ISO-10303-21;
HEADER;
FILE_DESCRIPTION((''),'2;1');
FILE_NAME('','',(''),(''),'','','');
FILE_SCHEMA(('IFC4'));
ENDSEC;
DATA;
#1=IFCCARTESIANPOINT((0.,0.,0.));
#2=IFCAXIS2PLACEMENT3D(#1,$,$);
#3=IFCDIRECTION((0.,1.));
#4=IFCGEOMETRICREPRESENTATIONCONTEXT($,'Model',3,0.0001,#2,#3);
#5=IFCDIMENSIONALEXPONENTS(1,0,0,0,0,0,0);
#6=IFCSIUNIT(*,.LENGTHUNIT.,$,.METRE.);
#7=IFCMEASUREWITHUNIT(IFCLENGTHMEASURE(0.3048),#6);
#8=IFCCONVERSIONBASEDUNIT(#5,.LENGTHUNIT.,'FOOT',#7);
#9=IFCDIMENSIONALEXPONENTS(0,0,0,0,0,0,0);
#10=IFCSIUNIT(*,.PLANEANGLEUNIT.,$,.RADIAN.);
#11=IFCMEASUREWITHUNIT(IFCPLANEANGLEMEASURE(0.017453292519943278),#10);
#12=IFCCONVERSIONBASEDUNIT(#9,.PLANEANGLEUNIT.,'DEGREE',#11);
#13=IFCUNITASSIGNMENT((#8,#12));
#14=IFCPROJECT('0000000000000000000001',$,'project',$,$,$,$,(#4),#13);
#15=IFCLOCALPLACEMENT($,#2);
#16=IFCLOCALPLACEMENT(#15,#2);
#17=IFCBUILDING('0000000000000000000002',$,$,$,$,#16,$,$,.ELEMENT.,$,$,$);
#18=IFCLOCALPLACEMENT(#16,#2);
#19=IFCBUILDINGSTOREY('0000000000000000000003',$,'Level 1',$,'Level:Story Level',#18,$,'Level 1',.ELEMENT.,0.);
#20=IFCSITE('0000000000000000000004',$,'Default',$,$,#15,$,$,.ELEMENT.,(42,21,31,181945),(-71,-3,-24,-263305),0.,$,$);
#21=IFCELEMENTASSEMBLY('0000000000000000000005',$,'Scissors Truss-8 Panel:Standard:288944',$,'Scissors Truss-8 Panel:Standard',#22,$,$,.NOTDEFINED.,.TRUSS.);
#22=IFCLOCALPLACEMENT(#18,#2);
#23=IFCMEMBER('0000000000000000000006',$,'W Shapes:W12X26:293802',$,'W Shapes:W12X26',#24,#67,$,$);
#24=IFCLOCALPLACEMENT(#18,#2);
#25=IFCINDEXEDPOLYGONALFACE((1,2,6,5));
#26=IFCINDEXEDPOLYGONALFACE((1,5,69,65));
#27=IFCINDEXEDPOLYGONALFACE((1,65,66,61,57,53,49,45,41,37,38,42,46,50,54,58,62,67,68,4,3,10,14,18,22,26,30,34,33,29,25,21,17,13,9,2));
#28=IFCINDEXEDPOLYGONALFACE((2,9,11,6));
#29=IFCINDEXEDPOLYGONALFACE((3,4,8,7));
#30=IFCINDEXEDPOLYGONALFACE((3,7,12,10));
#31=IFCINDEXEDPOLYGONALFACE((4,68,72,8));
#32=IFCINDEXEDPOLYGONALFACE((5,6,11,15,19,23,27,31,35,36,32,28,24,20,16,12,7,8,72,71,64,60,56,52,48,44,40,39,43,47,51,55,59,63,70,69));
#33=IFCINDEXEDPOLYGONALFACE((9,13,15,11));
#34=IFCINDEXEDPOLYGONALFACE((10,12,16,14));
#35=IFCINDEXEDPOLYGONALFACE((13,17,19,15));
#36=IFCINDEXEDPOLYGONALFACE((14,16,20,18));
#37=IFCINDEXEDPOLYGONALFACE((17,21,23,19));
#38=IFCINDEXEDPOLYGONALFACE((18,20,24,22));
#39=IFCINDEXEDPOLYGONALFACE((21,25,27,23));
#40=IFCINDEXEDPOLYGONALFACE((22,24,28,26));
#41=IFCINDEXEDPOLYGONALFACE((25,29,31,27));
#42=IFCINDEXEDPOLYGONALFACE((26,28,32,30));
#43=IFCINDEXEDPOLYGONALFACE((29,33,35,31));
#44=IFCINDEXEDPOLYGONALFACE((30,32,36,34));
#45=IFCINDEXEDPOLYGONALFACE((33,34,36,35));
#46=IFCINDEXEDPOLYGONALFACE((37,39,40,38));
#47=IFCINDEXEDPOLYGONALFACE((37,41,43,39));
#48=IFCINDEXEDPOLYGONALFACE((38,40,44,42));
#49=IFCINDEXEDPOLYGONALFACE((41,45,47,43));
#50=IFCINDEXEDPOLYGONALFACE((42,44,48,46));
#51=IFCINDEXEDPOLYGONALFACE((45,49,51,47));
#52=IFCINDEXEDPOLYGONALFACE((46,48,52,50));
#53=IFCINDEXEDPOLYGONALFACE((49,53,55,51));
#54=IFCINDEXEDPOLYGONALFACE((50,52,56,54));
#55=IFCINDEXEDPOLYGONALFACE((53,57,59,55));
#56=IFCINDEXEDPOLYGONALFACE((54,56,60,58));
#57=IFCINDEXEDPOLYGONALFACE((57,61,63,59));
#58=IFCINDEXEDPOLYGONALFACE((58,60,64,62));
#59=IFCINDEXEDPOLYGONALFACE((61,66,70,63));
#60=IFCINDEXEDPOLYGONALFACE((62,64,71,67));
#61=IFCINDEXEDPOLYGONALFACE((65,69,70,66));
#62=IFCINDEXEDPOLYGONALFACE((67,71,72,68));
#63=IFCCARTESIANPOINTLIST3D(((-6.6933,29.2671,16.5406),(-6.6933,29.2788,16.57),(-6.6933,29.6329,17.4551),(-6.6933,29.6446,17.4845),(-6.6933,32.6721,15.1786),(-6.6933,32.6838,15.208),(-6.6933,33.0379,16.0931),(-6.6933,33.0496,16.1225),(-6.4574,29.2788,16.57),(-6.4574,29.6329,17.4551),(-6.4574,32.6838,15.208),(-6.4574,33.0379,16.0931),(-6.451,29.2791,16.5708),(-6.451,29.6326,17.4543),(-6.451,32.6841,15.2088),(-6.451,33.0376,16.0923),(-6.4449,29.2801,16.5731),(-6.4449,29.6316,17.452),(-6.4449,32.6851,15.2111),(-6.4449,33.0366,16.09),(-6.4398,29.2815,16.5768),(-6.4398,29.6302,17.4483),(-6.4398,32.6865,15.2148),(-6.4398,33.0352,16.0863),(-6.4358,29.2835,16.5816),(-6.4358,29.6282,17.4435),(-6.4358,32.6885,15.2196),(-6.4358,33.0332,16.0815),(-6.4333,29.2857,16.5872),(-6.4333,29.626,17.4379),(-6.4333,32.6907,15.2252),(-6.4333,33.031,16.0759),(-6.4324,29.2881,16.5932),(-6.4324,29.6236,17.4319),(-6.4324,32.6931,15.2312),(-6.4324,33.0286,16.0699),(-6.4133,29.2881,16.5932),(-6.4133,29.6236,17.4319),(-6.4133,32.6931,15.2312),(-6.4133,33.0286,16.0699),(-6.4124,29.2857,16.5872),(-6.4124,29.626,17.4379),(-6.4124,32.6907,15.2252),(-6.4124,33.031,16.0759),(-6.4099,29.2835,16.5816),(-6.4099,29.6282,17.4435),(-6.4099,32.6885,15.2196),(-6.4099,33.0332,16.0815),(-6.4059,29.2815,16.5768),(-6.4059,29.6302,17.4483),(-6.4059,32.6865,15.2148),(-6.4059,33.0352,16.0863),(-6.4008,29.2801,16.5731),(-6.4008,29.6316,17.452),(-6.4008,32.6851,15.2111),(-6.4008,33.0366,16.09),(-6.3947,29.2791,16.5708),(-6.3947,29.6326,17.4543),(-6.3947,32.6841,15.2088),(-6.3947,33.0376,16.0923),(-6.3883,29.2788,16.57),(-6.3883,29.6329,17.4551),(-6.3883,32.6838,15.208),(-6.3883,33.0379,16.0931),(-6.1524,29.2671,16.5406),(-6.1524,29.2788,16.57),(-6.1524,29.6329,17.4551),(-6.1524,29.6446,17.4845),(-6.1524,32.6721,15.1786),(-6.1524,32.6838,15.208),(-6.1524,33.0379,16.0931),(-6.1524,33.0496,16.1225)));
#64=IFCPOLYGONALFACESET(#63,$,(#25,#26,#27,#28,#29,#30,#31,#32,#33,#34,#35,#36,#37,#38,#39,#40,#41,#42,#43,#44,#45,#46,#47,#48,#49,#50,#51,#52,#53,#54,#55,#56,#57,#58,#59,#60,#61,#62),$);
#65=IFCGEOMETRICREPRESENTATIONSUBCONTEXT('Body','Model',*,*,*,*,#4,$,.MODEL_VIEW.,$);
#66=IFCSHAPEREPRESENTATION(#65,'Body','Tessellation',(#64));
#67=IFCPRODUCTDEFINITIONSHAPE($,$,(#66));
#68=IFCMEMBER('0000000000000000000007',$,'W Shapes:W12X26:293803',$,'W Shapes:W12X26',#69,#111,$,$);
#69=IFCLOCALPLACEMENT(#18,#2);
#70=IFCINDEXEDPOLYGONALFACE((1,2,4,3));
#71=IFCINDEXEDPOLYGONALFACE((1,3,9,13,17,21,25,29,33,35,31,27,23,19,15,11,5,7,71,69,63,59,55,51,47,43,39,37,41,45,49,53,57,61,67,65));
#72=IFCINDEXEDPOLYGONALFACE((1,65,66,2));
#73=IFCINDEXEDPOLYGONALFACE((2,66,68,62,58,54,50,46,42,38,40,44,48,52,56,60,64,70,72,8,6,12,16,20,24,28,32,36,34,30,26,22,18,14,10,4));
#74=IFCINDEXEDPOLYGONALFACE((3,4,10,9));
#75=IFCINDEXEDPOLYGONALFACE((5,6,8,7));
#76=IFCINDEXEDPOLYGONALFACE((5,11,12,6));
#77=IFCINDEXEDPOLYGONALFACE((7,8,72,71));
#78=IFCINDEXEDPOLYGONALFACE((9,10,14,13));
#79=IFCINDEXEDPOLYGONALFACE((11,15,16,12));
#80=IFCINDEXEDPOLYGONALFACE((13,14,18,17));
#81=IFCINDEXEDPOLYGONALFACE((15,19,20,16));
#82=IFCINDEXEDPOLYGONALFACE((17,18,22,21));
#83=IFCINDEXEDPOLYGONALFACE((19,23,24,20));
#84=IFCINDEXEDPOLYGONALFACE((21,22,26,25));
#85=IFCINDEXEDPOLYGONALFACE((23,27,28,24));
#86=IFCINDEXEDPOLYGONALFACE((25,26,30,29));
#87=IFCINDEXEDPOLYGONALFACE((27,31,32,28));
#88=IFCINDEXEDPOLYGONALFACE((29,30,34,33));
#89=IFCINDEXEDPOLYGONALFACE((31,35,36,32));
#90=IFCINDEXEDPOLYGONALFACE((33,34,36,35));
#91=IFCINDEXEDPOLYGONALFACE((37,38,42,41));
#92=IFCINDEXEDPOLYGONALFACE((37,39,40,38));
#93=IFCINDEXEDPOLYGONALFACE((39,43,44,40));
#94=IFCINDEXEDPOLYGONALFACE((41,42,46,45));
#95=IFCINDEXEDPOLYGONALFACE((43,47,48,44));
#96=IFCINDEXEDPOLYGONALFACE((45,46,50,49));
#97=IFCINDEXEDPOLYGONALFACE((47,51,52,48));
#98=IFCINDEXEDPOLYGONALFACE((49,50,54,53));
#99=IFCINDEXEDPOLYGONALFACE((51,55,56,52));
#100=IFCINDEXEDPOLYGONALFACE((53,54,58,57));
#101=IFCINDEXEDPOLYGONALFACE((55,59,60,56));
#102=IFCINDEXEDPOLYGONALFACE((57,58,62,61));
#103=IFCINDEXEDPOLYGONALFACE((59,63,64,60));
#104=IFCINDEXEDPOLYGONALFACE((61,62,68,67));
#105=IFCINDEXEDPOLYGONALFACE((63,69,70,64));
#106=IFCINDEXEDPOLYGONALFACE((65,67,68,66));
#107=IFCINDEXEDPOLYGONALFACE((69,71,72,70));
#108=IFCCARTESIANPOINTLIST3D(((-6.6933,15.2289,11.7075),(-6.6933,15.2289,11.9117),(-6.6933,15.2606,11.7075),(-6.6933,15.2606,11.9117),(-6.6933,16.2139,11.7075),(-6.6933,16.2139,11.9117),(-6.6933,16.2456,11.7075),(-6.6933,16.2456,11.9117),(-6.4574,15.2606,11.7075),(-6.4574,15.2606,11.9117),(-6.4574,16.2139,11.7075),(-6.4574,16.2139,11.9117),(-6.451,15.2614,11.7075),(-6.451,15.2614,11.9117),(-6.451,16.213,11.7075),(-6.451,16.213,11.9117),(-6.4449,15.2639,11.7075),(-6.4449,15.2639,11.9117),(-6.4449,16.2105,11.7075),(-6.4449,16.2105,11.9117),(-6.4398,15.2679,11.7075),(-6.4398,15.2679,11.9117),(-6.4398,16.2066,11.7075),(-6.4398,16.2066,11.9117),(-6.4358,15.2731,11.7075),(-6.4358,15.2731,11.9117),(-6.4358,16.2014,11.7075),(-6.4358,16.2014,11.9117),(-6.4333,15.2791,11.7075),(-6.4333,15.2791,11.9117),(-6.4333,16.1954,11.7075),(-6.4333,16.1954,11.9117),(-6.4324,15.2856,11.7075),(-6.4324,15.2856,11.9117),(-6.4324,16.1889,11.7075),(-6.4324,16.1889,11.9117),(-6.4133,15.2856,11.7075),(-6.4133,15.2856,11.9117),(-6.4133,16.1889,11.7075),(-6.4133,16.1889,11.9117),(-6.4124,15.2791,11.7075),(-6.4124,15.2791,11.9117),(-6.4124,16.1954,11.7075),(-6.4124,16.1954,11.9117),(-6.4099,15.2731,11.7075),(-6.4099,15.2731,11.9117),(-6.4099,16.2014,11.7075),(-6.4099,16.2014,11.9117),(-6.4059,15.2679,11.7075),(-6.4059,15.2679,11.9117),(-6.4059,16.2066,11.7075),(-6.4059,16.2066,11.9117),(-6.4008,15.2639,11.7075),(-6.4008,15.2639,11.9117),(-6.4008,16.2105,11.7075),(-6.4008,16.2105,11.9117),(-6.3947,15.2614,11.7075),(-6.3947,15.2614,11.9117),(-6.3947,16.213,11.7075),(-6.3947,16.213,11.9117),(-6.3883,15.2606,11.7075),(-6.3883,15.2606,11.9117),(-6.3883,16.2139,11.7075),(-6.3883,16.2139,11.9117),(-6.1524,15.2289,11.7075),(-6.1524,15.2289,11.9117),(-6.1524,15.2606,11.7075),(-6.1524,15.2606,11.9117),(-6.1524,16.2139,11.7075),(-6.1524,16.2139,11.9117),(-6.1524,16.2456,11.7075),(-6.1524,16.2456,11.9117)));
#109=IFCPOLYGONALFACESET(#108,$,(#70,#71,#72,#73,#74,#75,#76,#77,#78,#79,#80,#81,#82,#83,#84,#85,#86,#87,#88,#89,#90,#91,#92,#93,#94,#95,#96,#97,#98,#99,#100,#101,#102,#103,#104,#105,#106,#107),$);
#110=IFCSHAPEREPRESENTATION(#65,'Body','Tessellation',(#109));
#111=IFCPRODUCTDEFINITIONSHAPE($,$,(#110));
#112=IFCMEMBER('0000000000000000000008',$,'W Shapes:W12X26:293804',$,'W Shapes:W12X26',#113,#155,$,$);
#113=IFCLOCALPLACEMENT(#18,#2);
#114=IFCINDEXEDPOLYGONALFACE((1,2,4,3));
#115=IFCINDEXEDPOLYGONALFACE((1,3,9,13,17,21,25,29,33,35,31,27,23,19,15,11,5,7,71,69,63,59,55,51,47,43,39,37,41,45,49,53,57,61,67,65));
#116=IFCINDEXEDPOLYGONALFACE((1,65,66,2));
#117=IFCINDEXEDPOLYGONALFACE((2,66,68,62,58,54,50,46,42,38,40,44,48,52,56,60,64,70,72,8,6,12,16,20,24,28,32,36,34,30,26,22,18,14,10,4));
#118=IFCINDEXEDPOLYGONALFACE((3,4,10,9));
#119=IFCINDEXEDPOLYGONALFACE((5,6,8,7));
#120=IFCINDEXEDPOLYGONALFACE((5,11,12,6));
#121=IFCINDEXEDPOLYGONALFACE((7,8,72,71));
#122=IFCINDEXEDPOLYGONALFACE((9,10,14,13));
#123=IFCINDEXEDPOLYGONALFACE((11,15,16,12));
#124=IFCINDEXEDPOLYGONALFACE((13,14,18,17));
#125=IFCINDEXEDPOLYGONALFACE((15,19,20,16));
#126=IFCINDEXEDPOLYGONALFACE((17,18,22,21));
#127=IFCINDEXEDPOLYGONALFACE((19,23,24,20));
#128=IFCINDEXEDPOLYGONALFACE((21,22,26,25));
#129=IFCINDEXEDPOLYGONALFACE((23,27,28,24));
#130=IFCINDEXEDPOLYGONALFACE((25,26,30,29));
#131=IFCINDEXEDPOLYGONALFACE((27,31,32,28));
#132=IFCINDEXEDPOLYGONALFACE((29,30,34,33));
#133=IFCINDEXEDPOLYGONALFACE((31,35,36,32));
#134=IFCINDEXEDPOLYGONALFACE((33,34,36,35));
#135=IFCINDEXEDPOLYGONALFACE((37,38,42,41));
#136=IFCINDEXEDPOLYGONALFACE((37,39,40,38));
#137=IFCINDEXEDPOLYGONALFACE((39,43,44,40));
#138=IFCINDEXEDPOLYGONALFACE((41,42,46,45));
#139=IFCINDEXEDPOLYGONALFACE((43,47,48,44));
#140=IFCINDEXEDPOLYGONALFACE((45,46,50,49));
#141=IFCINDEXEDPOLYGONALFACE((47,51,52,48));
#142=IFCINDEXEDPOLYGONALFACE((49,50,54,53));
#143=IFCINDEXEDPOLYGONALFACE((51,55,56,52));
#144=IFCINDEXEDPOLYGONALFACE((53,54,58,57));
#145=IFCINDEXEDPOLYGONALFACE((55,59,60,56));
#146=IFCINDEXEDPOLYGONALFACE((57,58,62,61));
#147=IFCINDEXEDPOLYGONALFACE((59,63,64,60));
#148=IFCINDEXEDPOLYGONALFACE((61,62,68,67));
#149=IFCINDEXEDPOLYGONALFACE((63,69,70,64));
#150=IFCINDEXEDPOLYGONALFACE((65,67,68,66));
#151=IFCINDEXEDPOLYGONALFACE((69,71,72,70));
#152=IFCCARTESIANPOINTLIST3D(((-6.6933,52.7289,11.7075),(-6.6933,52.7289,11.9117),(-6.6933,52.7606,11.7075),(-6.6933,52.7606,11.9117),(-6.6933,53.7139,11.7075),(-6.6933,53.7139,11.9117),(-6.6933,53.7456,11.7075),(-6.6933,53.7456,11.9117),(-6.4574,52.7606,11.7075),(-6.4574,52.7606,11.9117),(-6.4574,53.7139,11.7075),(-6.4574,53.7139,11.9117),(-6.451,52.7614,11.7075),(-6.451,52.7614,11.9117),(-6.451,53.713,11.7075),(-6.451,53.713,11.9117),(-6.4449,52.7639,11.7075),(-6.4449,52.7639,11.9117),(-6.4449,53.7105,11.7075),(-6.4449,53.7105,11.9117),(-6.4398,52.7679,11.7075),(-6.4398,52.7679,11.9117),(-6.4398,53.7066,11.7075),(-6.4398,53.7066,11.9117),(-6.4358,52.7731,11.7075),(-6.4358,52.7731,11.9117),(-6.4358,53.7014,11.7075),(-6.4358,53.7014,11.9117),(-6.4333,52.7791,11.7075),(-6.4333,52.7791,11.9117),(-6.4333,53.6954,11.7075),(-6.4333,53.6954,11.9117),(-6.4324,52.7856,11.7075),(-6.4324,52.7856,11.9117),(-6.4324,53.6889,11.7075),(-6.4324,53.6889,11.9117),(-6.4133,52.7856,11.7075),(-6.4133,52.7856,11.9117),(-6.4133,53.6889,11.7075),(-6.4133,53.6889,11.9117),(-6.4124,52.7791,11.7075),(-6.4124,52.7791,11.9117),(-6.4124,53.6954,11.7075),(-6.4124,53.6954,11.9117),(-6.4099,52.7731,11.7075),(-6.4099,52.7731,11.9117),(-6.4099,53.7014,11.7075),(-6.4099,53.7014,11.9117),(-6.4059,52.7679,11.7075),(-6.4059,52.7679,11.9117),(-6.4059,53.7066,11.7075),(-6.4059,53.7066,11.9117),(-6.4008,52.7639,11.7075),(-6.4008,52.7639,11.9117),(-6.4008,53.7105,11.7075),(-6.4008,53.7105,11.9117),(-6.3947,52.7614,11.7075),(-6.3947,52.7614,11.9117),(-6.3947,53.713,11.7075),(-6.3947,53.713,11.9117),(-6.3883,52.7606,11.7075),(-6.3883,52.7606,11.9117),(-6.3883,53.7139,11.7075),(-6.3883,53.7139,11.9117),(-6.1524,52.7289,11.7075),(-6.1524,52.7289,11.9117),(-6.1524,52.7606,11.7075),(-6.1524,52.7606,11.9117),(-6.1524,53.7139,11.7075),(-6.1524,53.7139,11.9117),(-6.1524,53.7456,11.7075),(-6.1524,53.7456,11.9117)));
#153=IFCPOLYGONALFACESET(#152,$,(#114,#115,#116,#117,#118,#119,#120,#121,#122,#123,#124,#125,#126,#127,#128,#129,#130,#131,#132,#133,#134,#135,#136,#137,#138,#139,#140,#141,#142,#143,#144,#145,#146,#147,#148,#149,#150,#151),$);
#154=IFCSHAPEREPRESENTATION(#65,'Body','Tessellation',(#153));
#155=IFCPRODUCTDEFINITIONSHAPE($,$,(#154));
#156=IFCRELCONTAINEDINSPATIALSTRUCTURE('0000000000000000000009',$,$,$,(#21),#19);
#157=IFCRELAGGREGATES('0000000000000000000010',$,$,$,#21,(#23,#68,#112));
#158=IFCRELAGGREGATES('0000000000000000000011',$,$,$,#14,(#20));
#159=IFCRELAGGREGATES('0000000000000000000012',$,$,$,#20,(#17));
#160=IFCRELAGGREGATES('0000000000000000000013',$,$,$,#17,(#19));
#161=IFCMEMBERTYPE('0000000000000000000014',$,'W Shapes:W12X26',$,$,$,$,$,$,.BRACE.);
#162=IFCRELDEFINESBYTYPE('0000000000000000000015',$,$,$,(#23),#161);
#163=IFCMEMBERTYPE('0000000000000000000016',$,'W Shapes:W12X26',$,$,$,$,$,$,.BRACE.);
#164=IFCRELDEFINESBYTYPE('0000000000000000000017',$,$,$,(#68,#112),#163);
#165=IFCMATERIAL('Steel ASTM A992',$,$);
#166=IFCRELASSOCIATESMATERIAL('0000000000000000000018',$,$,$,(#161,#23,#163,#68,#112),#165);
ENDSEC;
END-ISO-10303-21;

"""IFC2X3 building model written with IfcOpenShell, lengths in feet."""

from ifc_helpers import new_model, entity, si_unit, converted_unit, direction, frame, frame_2d, origin, place, context, subcontext, project, spatial, polyline, circle_curve, parameter, trimmed, segment, composite_curve, outline, extrude, source, transform, mapped, material, type_object, type_shapes, element, aggregate, save


model = new_model("IFC2X3")

# Units and contexts
model_context = context("Model", 3, precision=0.0001, world=origin(), true_north=direction((0.0, 1.0)))
body_context = subcontext(model_context, "Body", "Model", "MODEL_VIEW")
ifc_project = project(units=[converted_unit("LENGTHUNIT", "FOOT", entity("IfcLengthMeasure", 0.3048), si_unit("LENGTHUNIT", "METRE"), dimensions=[1, 0, 0, 0, 0, 0, 0]), converted_unit("PLANEANGLEUNIT", "DEGREE", entity("IfcPlaneAngleMeasure", 0.017453292519943278), si_unit("PLANEANGLEUNIT", "RADIAN"), dimensions=[0, 0, 0, 0, 0, 0, 0])], contexts=[model_context])

# Site, building, storey
site_placement = place(None, origin())
site = spatial("IfcSite", under=ifc_project, at=site_placement, Name="Default", CompositionType="ELEMENT", RefLatitude=(42, 21, 31, 181945), RefLongitude=(-71, -3, -24, -263305), RefElevation=0.0)
building_placement = place(site_placement, origin())
building = spatial("IfcBuilding", under=site, at=building_placement, CompositionType="ELEMENT")
storey_placement = place(building_placement, origin())
storey = spatial("IfcBuildingStorey", under=building, at=storey_placement, Name="Level 1", ObjectType="Level:Story Level", LongName="Level 1", CompositionType="ELEMENT", Elevation=0.0)

# Element assembly, members
assembly_placement = place(storey_placement, origin())
assembly = element("IfcElementAssembly", 1, at=assembly_placement, inside=storey, Name="Scissors Truss-8 Panel:Standard:288944", ObjectType="Scissors Truss-8 Panel:Standard", AssemblyPlace="NOTDEFINED", PredefinedType="TRUSS")
ifc_material = material(Name="Steel ASTM A992")
member_type_1 = type_object("IfcMemberType", Name="W Shapes:W12X26", PredefinedType="BRACE", material=ifc_material)
shared_shape_1 = source(origin(), body_context, "Body", "SweptSolid", [
    extrude(outline(composite_curve([segment(polyline([(-0.2704, -0.4767), (-0.2704, -0.5083)]), True, "CONTINUOUS"), segment(polyline([(-0.2704, -0.5083), (0.2704, -0.5083)]), True, "CONTINUOUS"), segment(polyline([(0.2704, -0.5083), (0.2704, -0.4767)]), True, "CONTINUOUS"), segment(polyline([(0.2704, -0.4767), (0.0346, -0.4767)]), True, "CONTINUOUS"), segment(trimmed(circle_curve(frame_2d((0.0346, -0.4517), x_axis=(1.0, 0.0)), 0.025), [parameter(180.0)], [parameter(270.0)], True, "PARAMETER"), False, "CONTINUOUS"), segment(polyline([(0.0096, -0.4517), (0.0096, 0.4517)]), True, "CONTINUOUS"), segment(trimmed(circle_curve(frame_2d((0.0346, 0.4517), x_axis=(1.0, 0.0)), 0.025), [parameter(90.0)], [parameter(180.0)], True, "PARAMETER"), False, "CONTINUOUS"), segment(polyline([(0.0346, 0.4767), (0.2704, 0.4767)]), True, "CONTINUOUS"), segment(polyline([(0.2704, 0.4767), (0.2704, 0.5083)]), True, "CONTINUOUS"), segment(polyline([(0.2704, 0.5083), (-0.2704, 0.5083)]), True, "CONTINUOUS"), segment(polyline([(-0.2704, 0.5083), (-0.2704, 0.4767)]), True, "CONTINUOUS"), segment(polyline([(-0.2704, 0.4767), (-0.0346, 0.4767)]), True, "CONTINUOUS"), segment(trimmed(circle_curve(frame_2d((-0.0346, 0.4517), x_axis=(1.0, 0.0)), 0.025), [parameter(360.0)], [parameter(90.0)], True, "PARAMETER"), False, "CONTINUOUS"), segment(polyline([(-0.0096, 0.4517), (-0.0096, -0.4517)]), True, "CONTINUOUS"), segment(trimmed(circle_curve(frame_2d((-0.0346, -0.4517), x_axis=(1.0, 0.0)), 0.025), [parameter(270.0)], [parameter(360.0)], True, "PARAMETER"), False, "CONTINUOUS"), segment(polyline([(-0.0346, -0.4767), (-0.2704, -0.4767)]), True, "CONTINUOUS")], self_intersect=False)), frame((-2.0532, 0.0, 0.0), z_axis=(-1.0, 0.0, 0.0), x_axis=(0.0, -1.0, 0.0)), (0.0, 0.0, -1.0), 3.6673),
])
type_shapes(member_type_1, [shared_shape_1])
member_1_placement = place(assembly_placement, frame((-6.4228, 31.3622, 16.25), z_axis=(0.0, -0.371391, -0.928477), x_axis=(0.0, 0.928477, -0.371391)))
member_1 = element("IfcMember", 2, at=member_1_placement, type_object=member_type_1, material=ifc_material, Name="W Shapes:W12X26:293802", ObjectType="W Shapes:W12X26", context=body_context, shape_type="MappedRepresentation", body=[
    mapped(shared_shape_1, transform((0.0, 0.0, 0.0), scale=1.0)),
])
member_type_2 = type_object("IfcMemberType", Name="W Shapes:W12X26", PredefinedType="BRACE", material=ifc_material)
shared_shape_2 = source(origin(), body_context, "Body", "SweptSolid", [
    extrude(outline(composite_curve([segment(polyline([(0.4767, -0.2704), (0.5083, -0.2704)]), True, "CONTINUOUS"), segment(polyline([(0.5083, -0.2704), (0.5083, 0.2704)]), True, "CONTINUOUS"), segment(polyline([(0.5083, 0.2704), (0.4767, 0.2704)]), True, "CONTINUOUS"), segment(polyline([(0.4767, 0.2704), (0.4767, 0.0346)]), True, "CONTINUOUS"), segment(trimmed(circle_curve(frame_2d((0.4517, 0.0346), x_axis=(0.0, 1.0)), 0.025), [parameter(180.0)], [parameter(270.0)], True, "PARAMETER"), False, "CONTINUOUS"), segment(polyline([(0.4517, 0.0096), (-0.4517, 0.0096)]), True, "CONTINUOUS"), segment(trimmed(circle_curve(frame_2d((-0.4517, 0.0346), x_axis=(0.0, 1.0)), 0.025), [parameter(90.0)], [parameter(180.0)], True, "PARAMETER"), False, "CONTINUOUS"), segment(polyline([(-0.4767, 0.0346), (-0.4767, 0.2704)]), True, "CONTINUOUS"), segment(polyline([(-0.4767, 0.2704), (-0.5083, 0.2704)]), True, "CONTINUOUS"), segment(polyline([(-0.5083, 0.2704), (-0.5083, -0.2704)]), True, "CONTINUOUS"), segment(polyline([(-0.5083, -0.2704), (-0.4767, -0.2704)]), True, "CONTINUOUS"), segment(polyline([(-0.4767, -0.2704), (-0.4767, -0.0346)]), True, "CONTINUOUS"), segment(trimmed(circle_curve(frame_2d((-0.4517, -0.0346), x_axis=(0.0, 1.0)), 0.025), [parameter(360.0)], [parameter(90.0)], True, "PARAMETER"), False, "CONTINUOUS"), segment(polyline([(-0.4517, -0.0096), (0.4517, -0.0096)]), True, "CONTINUOUS"), segment(trimmed(circle_curve(frame_2d((0.4517, -0.0346), x_axis=(0.0, 1.0)), 0.025), [parameter(270.0)], [parameter(360.0)], True, "PARAMETER"), False, "CONTINUOUS"), segment(polyline([(0.4767, -0.0346), (0.4767, -0.2704)]), True, "CONTINUOUS")], self_intersect=False)), frame((-0.1675, 0.0, 0.0), z_axis=(1.0, 0.0, 0.0), x_axis=(0.0, 0.0, -1.0)), (0.0, 0.0, 1.0), 0.2042),
])
type_shapes(member_type_2, [shared_shape_2])
member_2_placement = place(assembly_placement, frame((-6.4228, 15.7372, 11.875), z_axis=(0.0, 1.0, 0.0), x_axis=(0.0, 0.0, 1.0)))
member_2 = element("IfcMember", 3, at=member_2_placement, type_object=member_type_2, material=ifc_material, Name="W Shapes:W12X26:293803", ObjectType="W Shapes:W12X26", context=body_context, shape_type="MappedRepresentation", body=[
    mapped(shared_shape_2, transform((0.0, 0.0, 0.0), scale=1.0)),
])
member_3_placement = place(assembly_placement, frame((-6.4228, 53.2372, 11.875), z_axis=(0.0, 1.0, 0.0), x_axis=(0.0, 0.0, 1.0)))
member_3 = element("IfcMember", 4, at=member_3_placement, type_object=member_type_2, material=ifc_material, Name="W Shapes:W12X26:293804", ObjectType="W Shapes:W12X26", context=body_context, shape_type="MappedRepresentation", body=[
    mapped(shared_shape_2, transform((0.0, 0.0, 0.0), scale=1.0)),
])
aggregate(assembly, [member_1, member_2, member_3])

save(model, "model.ifc")
